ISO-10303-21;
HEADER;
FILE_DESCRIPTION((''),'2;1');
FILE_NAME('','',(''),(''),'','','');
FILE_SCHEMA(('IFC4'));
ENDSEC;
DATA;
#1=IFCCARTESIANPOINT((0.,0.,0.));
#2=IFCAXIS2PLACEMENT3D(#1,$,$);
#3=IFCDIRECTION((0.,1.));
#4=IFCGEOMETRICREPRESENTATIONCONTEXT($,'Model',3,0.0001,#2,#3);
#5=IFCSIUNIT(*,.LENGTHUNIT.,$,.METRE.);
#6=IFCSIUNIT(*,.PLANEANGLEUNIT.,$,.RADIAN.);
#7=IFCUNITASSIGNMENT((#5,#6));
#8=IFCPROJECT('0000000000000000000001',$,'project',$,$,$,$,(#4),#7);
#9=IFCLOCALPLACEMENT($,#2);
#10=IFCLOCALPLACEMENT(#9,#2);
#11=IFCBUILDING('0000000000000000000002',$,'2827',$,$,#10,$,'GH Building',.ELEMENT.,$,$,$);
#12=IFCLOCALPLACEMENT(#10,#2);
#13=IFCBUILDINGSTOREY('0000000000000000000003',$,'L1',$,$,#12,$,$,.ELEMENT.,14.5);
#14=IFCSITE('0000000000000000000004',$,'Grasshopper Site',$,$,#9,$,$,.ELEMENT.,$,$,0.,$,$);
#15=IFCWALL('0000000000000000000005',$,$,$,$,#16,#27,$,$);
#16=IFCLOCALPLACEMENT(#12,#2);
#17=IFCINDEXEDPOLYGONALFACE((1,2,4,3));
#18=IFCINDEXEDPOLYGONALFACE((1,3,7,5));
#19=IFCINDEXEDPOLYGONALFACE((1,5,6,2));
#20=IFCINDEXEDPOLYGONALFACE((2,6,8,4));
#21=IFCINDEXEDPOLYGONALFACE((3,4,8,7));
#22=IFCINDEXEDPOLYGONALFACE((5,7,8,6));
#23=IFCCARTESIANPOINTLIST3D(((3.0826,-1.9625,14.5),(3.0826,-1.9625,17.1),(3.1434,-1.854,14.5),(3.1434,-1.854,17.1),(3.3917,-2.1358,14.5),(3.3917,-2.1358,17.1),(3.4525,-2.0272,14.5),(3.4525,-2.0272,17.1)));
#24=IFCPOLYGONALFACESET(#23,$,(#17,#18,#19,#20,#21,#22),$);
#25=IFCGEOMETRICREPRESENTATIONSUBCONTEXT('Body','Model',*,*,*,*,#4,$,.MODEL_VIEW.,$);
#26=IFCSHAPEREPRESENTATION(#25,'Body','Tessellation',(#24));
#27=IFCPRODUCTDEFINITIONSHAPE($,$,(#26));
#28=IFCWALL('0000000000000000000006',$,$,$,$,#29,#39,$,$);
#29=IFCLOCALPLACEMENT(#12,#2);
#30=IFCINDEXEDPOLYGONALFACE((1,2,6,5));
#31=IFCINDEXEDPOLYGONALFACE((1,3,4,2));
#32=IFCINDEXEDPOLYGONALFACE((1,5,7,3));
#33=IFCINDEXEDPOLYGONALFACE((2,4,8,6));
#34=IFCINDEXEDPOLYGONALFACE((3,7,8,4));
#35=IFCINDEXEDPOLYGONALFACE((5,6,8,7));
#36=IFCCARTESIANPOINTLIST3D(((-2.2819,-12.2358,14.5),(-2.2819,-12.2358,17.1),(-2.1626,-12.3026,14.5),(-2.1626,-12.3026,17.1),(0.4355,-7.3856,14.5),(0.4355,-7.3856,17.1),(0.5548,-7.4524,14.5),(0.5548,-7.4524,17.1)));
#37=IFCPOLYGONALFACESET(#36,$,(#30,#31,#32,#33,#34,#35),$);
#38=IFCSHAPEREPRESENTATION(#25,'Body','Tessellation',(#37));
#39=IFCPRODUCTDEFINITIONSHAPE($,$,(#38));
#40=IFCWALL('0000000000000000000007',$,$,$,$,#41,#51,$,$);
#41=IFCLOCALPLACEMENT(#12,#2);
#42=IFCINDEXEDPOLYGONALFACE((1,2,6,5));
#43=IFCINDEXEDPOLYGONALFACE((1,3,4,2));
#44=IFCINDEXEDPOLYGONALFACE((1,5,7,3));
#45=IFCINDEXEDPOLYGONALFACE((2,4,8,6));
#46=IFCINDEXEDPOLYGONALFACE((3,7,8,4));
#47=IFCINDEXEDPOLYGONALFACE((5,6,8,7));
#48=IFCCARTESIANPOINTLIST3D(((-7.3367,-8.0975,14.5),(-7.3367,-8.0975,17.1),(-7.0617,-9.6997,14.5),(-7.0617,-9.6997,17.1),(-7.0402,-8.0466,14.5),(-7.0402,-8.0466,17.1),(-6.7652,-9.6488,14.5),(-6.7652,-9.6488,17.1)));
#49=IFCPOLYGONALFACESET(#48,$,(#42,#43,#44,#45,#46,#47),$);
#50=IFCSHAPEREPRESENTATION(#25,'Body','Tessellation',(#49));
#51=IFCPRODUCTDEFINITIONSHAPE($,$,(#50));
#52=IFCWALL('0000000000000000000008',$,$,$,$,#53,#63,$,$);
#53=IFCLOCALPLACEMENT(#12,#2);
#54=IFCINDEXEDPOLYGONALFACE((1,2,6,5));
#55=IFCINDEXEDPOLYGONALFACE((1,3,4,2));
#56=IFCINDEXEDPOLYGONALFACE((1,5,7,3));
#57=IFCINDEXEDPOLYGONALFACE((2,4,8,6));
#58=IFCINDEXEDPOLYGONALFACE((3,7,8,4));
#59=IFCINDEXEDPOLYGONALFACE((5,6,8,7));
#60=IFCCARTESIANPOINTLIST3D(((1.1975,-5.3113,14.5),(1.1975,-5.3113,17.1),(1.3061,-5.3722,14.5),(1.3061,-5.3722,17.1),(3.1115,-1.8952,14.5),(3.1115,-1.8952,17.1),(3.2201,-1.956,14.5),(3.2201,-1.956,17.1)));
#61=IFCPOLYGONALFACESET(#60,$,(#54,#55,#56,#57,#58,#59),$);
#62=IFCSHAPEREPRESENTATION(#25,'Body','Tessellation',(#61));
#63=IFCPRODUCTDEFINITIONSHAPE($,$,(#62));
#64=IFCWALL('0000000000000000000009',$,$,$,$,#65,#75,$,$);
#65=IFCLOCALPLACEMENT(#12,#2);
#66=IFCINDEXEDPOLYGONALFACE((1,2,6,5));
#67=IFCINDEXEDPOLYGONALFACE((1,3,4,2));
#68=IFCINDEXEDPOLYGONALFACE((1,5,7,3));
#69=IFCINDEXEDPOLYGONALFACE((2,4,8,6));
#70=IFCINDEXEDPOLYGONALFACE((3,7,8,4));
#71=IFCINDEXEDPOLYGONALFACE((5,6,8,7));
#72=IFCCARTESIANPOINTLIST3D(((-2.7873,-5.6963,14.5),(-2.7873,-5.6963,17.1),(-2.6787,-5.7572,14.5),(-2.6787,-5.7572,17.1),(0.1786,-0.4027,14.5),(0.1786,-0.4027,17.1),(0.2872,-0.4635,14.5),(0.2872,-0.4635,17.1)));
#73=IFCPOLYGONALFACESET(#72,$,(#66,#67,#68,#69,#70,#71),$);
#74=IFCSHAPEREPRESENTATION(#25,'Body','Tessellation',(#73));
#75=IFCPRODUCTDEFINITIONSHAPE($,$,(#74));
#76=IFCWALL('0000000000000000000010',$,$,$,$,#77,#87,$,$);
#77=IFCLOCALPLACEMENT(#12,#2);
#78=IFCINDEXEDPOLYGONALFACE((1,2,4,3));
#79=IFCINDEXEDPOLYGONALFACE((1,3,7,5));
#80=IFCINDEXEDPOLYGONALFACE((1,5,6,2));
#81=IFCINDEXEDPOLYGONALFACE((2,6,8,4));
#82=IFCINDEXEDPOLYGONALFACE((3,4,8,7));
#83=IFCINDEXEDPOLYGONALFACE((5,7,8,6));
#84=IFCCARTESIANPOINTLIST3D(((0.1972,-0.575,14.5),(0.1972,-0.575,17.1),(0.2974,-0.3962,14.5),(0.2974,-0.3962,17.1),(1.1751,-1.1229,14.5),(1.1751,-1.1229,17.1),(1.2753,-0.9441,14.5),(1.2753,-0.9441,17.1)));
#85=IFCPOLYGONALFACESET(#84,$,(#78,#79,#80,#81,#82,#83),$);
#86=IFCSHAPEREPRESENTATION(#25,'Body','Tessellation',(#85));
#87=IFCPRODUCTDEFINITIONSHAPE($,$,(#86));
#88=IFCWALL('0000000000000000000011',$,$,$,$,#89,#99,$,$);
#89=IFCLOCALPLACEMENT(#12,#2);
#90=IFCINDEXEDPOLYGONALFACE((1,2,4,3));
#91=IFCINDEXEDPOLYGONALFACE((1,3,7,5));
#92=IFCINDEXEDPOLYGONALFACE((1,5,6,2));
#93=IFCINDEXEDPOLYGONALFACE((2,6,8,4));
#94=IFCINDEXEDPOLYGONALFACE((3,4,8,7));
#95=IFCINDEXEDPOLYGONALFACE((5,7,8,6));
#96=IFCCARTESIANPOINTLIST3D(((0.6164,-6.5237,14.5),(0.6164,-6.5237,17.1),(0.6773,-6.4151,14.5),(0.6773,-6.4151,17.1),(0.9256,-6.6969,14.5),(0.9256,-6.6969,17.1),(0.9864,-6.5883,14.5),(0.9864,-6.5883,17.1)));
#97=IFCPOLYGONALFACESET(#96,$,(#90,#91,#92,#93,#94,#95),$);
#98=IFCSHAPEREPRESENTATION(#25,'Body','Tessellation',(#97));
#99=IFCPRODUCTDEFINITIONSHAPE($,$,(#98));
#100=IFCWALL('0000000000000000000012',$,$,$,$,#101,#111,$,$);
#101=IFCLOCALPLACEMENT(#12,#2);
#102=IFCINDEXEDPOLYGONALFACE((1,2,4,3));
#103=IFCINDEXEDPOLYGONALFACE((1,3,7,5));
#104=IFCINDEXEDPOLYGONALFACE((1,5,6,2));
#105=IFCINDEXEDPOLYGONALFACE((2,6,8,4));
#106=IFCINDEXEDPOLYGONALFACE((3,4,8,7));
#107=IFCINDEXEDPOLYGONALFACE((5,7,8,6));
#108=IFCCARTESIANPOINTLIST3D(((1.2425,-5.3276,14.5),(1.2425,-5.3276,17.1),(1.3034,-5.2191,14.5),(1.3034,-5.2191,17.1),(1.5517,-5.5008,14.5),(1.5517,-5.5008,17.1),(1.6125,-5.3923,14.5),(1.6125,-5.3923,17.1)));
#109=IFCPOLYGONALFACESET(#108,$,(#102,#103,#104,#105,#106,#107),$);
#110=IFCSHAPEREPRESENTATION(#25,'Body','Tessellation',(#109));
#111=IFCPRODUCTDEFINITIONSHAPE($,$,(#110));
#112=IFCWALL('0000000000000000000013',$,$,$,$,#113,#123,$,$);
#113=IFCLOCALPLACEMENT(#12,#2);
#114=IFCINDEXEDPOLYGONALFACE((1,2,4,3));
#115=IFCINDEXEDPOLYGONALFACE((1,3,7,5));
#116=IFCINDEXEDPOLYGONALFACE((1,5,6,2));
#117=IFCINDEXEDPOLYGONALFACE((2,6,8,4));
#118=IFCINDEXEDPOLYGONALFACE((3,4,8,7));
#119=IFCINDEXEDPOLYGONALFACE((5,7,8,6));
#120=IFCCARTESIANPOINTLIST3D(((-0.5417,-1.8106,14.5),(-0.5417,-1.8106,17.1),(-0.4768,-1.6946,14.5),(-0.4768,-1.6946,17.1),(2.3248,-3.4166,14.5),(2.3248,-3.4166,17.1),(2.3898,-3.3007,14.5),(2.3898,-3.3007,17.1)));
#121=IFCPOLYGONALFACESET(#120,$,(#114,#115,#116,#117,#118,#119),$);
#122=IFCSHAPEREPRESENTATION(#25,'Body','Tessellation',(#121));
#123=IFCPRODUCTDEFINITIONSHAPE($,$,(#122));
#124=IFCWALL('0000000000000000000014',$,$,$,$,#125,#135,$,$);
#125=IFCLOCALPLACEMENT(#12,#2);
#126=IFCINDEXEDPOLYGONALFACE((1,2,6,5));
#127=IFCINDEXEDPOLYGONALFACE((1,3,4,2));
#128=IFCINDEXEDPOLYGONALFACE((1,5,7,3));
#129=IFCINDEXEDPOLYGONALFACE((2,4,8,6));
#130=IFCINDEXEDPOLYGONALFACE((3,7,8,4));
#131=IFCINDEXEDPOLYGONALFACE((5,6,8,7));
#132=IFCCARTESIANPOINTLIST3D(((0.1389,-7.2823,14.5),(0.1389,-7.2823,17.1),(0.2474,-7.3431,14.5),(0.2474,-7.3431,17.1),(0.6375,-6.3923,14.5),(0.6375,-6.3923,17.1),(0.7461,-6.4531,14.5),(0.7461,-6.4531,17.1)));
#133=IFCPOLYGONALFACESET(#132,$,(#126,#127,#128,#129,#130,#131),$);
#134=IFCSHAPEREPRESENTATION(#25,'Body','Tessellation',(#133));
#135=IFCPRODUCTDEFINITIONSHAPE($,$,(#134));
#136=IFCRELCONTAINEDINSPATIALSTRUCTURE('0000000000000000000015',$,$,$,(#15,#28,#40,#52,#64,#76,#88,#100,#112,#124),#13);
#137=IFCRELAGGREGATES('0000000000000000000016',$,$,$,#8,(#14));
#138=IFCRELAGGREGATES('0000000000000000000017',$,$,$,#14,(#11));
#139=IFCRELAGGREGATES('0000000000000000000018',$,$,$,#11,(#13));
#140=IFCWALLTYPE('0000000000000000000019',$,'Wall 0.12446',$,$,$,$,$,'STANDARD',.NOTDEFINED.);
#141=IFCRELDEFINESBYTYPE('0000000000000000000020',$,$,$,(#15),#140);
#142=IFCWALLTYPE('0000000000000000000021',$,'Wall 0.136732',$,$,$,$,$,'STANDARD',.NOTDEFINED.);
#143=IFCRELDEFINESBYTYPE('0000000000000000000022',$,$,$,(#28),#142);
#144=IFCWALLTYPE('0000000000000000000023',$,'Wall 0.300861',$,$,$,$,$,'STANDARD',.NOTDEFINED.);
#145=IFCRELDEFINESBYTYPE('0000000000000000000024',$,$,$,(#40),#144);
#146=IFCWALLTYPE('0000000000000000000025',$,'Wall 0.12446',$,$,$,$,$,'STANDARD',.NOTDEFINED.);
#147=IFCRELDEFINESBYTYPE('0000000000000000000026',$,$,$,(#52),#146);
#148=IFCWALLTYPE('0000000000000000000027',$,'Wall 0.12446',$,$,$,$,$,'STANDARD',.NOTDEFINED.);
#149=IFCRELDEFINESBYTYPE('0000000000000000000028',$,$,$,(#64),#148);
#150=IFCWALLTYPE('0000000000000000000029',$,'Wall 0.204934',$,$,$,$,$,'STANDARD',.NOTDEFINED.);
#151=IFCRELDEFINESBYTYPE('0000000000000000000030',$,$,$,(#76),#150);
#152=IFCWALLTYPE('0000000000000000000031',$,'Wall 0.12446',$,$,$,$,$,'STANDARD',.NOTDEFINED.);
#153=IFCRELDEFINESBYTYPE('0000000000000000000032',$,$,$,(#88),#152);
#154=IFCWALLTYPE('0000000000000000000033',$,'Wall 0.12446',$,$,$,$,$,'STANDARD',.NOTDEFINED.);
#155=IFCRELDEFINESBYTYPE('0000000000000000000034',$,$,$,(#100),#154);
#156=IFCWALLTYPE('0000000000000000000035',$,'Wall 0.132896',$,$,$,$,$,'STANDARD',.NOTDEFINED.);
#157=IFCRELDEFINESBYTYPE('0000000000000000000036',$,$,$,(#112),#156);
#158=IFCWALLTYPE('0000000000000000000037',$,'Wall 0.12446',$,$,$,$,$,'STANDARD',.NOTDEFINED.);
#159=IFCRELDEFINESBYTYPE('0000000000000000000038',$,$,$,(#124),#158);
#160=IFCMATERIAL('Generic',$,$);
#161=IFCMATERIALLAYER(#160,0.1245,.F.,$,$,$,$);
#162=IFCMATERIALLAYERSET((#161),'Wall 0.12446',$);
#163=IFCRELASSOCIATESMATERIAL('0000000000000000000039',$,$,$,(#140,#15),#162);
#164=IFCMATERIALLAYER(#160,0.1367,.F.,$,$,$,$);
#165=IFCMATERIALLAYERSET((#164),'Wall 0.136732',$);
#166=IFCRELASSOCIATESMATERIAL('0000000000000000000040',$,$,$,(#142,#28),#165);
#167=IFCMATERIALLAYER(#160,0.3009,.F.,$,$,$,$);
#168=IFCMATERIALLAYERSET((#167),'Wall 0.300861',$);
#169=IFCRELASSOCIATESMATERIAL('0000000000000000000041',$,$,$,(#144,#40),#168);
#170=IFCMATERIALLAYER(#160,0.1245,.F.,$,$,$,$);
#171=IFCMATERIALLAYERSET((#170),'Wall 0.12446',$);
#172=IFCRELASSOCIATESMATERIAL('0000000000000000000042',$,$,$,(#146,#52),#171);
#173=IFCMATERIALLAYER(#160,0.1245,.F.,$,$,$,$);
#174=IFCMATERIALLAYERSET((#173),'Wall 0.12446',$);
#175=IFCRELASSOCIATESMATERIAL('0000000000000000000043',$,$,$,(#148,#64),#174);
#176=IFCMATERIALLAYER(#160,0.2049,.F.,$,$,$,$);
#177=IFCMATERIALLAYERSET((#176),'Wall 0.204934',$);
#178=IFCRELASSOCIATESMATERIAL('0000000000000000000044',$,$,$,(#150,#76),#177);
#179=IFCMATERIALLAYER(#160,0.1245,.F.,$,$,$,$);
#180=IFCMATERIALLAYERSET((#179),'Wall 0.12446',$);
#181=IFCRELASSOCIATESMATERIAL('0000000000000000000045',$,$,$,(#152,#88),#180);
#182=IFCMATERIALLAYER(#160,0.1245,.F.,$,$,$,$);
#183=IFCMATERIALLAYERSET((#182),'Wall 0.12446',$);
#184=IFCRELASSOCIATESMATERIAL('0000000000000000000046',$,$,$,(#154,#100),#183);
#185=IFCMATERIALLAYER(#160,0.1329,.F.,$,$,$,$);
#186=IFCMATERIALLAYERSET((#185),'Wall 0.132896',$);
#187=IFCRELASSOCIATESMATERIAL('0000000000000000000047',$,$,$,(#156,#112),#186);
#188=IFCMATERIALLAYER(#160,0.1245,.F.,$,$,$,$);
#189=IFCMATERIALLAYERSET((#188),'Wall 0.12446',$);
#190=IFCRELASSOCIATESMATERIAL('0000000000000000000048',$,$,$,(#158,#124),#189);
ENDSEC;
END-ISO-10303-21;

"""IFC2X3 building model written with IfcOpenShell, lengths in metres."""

from ifc_helpers import new_model, si_unit, direction, frame, frame_2d, origin, place, context, subcontext, project, spatial, rectangle, extrude, material, layer, layer_set, layer_usage, type_object, element, save


model = new_model("IFC2X3")

# Units and contexts
model_context = context("Model", 3, precision=0.0001, world=origin(), true_north=direction((0.0, 1.0)))
body_context = subcontext(model_context, "Body", "Model", "MODEL_VIEW")
ifc_project = project(units=[si_unit("LENGTHUNIT", "METRE"), si_unit("PLANEANGLEUNIT", "RADIAN")], contexts=[model_context])

# Site, building, storey
site_placement = place(None, origin())
site = spatial("IfcSite", under=ifc_project, at=site_placement, Name="Grasshopper Site", CompositionType="ELEMENT", RefElevation=0.0)
building_placement = place(site_placement, origin())
building = spatial("IfcBuilding", under=site, at=building_placement, Name="2827", LongName="GH Building", CompositionType="ELEMENT")
storey_placement = place(building_placement, origin())
storey = spatial("IfcBuildingStorey", under=building, at=storey_placement, Name="L1", CompositionType="ELEMENT", Elevation=14.5)

# Shared definitions
ifc_material_1 = material(Name="Generic")

# Walls
ifc_layer_1 = layer(ifc_material_1, 0.1245, ventilated=False)
ifc_layer_set_1 = layer_set([ifc_layer_1], Name="Wall 0.12446")
ifc_layer_usage_1 = layer_usage(ifc_layer_set_1, "AXIS2", "NEGATIVE", 0.0622)
wall_type_1 = type_object("IfcWallType", Name="Wall 0.12446", ElementType="STANDARD", PredefinedType="NOTDEFINED", material=ifc_layer_set_1)
wall_1_placement = place(storey_placement, frame((3.113, -1.9083, 14.5), z_axis=(0.0, 0.0, 1.0), x_axis=(0.872406, -0.488782, 0.0)))
element("IfcWall", 1, at=wall_1_placement, inside=storey, type_object=wall_type_1, material=ifc_layer_usage_1, context=body_context, shape_type="SweptSolid", body=[
    extrude(rectangle(XDim=0.3544, YDim=0.1245, at=frame_2d((0.1772, 0.0))), origin(), (0.0, 0.0, 1.0), 2.6),
])
ifc_layer_2 = layer(ifc_material_1, 0.1367, ventilated=False)
ifc_layer_set_2 = layer_set([ifc_layer_2], Name="Wall 0.136732")
ifc_layer_usage_2 = layer_usage(ifc_layer_set_2, "AXIS2", "NEGATIVE", 0.0684)
wall_type_2 = type_object("IfcWallType", Name="Wall 0.136732", ElementType="STANDARD", PredefinedType="NOTDEFINED", material=ifc_layer_set_2)
wall_2_placement = place(storey_placement, frame((-2.2222, -12.2692, 14.5), z_axis=(0.0, 0.0, 1.0), x_axis=(0.488782, 0.872406, 0.0)))
element("IfcWall", 2, at=wall_2_placement, inside=storey, type_object=wall_type_2, material=ifc_layer_usage_2, context=body_context, shape_type="SweptSolid", body=[
    extrude(rectangle(XDim=5.5595, YDim=0.1367, at=frame_2d((2.7798, 0.0))), origin(), (0.0, 0.0, 1.0), 2.6),
])

# Walls
ifc_layer_3 = layer(ifc_material_1, 0.3009, ventilated=False)
ifc_layer_set_3 = layer_set([ifc_layer_3], Name="Wall 0.300861")
ifc_layer_usage_3 = layer_usage(ifc_layer_set_3, "AXIS2", "NEGATIVE", 0.1504)
wall_type_3 = type_object("IfcWallType", Name="Wall 0.300861", ElementType="STANDARD", PredefinedType="NOTDEFINED", material=ifc_layer_set_3)
wall_3_placement = place(storey_placement, frame((-7.1885, -8.072, 14.5), z_axis=(0.0, 0.0, 1.0), x_axis=(0.169168, -0.985587, 0.0)))
element("IfcWall", 3, at=wall_3_placement, inside=storey, type_object=wall_type_3, material=ifc_layer_usage_3, context=body_context, shape_type="SweptSolid", body=[
    extrude(rectangle(XDim=1.6256, YDim=0.3009, at=frame_2d((0.8128, 0.0))), origin(), (0.0, 0.0, 1.0), 2.6),
])
ifc_layer_4 = layer(ifc_material_1, 0.1245, ventilated=False)
ifc_layer_set_4 = layer_set([ifc_layer_4], Name="Wall 0.12446")
ifc_layer_usage_4 = layer_usage(ifc_layer_set_4, "AXIS2", "NEGATIVE", 0.0622)
wall_type_4 = type_object("IfcWallType", Name="Wall 0.12446", ElementType="STANDARD", PredefinedType="NOTDEFINED", material=ifc_layer_set_4)
wall_4_placement = place(storey_placement, frame((3.1658, -1.9256, 14.5), z_axis=(0.0, 0.0, 1.0), x_axis=(-0.488782, -0.872406, 0.0)))
element("IfcWall", 4, at=wall_4_placement, inside=storey, type_object=wall_type_4, material=ifc_layer_usage_4, context=body_context, shape_type="SweptSolid", body=[
    extrude(rectangle(XDim=3.9158, YDim=0.1245, at=frame_2d((1.9579, 0.0))), origin(), (0.0, 0.0, 1.0), 2.6),
])
ifc_layer_5 = layer(ifc_material_1, 0.1245, ventilated=False)
ifc_layer_set_5 = layer_set([ifc_layer_5], Name="Wall 0.12446")
ifc_layer_usage_5 = layer_usage(ifc_layer_set_5, "AXIS2", "NEGATIVE", 0.0622)
wall_type_5 = type_object("IfcWallType", Name="Wall 0.12446", ElementType="STANDARD", PredefinedType="NOTDEFINED", material=ifc_layer_set_5)
wall_5_placement = place(storey_placement, frame((-2.733, -5.7268, 14.5), z_axis=(0.0, 0.0, 1.0), x_axis=(0.488782, 0.872406, 0.0)))
element("IfcWall", 5, at=wall_5_placement, inside=storey, type_object=wall_type_5, material=ifc_layer_usage_5, context=body_context, shape_type="SweptSolid", body=[
    extrude(rectangle(XDim=6.0679, YDim=0.1245, at=frame_2d((3.034, 0.0))), origin(), (0.0, 0.0, 1.0), 2.6),
])
ifc_layer_6 = layer(ifc_material_1, 0.2049, ventilated=False)
ifc_layer_set_6 = layer_set([ifc_layer_6], Name="Wall 0.204934")
ifc_layer_usage_6 = layer_usage(ifc_layer_set_6, "AXIS2", "NEGATIVE", 0.1025)
wall_type_6 = type_object("IfcWallType", Name="Wall 0.204934", ElementType="STANDARD", PredefinedType="NOTDEFINED", material=ifc_layer_set_6)
wall_6_placement = place(storey_placement, frame((1.2252, -1.0335, 14.5), z_axis=(0.0, 0.0, 1.0), x_axis=(-0.872406, 0.488782, 0.0)))
element("IfcWall", 6, at=wall_6_placement, inside=storey, type_object=wall_type_6, material=ifc_layer_usage_6, context=body_context, shape_type="SweptSolid", body=[
    extrude(rectangle(XDim=1.1209, YDim=0.2049, at=frame_2d((0.5605, 0.0))), origin(), (0.0, 0.0, 1.0), 2.6),
])
ifc_layer_7 = layer(ifc_material_1, 0.1245, ventilated=False)
ifc_layer_set_7 = layer_set([ifc_layer_7], Name="Wall 0.12446")
ifc_layer_usage_7 = layer_usage(ifc_layer_set_7, "AXIS2", "NEGATIVE", 0.0622)
wall_type_7 = type_object("IfcWallType", Name="Wall 0.12446", ElementType="STANDARD", PredefinedType="NOTDEFINED", material=ifc_layer_set_7)
wall_7_placement = place(storey_placement, frame((0.956, -6.6426, 14.5), z_axis=(0.0, 0.0, 1.0), x_axis=(-0.872406, 0.488782, 0.0)))
element("IfcWall", 7, at=wall_7_placement, inside=storey, type_object=wall_type_7, material=ifc_layer_usage_7, context=body_context, shape_type="SweptSolid", body=[
    extrude(rectangle(XDim=0.3544, YDim=0.1245, at=frame_2d((0.1772, 0.0))), origin(), (0.0, 0.0, 1.0), 2.6),
])
ifc_layer_8 = layer(ifc_material_1, 0.1245, ventilated=False)
ifc_layer_set_8 = layer_set([ifc_layer_8], Name="Wall 0.12446")
ifc_layer_usage_8 = layer_usage(ifc_layer_set_8, "AXIS2", "NEGATIVE", 0.0622)
wall_type_8 = type_object("IfcWallType", Name="Wall 0.12446", ElementType="STANDARD", PredefinedType="NOTDEFINED", material=ifc_layer_set_8)
wall_8_placement = place(storey_placement, frame((1.273, -5.2733, 14.5), z_axis=(0.0, 0.0, 1.0), x_axis=(0.872406, -0.488782, 0.0)))
element("IfcWall", 8, at=wall_8_placement, inside=storey, type_object=wall_type_8, material=ifc_layer_usage_8, context=body_context, shape_type="SweptSolid", body=[
    extrude(rectangle(XDim=0.3544, YDim=0.1245, at=frame_2d((0.1772, 0.0))), origin(), (0.0, 0.0, 1.0), 2.6),
])
ifc_layer_9 = layer(ifc_material_1, 0.1329, ventilated=False)
ifc_layer_set_9 = layer_set([ifc_layer_9], Name="Wall 0.132896")
ifc_layer_usage_9 = layer_usage(ifc_layer_set_9, "AXIS2", "NEGATIVE", 0.0664)
wall_type_9 = type_object("IfcWallType", Name="Wall 0.132896", ElementType="STANDARD", PredefinedType="NOTDEFINED", material=ifc_layer_set_9)
wall_9_placement = place(storey_placement, frame((-0.5092, -1.7526, 14.5), z_axis=(0.0, 0.0, 1.0), x_axis=(0.872406, -0.488782, 0.0)))
element("IfcWall", 9, at=wall_9_placement, inside=storey, type_object=wall_type_9, material=ifc_layer_usage_9, context=body_context, shape_type="SweptSolid", body=[
    extrude(rectangle(XDim=3.2858, YDim=0.1329, at=frame_2d((1.6429, 0.0))), origin(), (0.0, 0.0, 1.0), 2.6),
])
ifc_layer_10 = layer(ifc_material_1, 0.1245, ventilated=False)
ifc_layer_set_10 = layer_set([ifc_layer_10], Name="Wall 0.12446")
ifc_layer_usage_10 = layer_usage(ifc_layer_set_10, "AXIS2", "NEGATIVE", 0.0622)
wall_type_10 = type_object("IfcWallType", Name="Wall 0.12446", ElementType="STANDARD", PredefinedType="NOTDEFINED", material=ifc_layer_set_10)
wall_10_placement = place(storey_placement, frame((0.6918, -6.4227, 14.5), z_axis=(0.0, 0.0, 1.0), x_axis=(-0.488782, -0.872406, 0.0)))
element("IfcWall", 10, at=wall_10_placement, inside=storey, type_object=wall_type_10, material=ifc_layer_usage_10, context=body_context, shape_type="SweptSolid", body=[
    extrude(rectangle(XDim=1.0202, YDim=0.1245, at=frame_2d((0.5101, 0.0))), origin(), (0.0, 0.0, 1.0), 2.6),
])

save(model, "model.ifc")
